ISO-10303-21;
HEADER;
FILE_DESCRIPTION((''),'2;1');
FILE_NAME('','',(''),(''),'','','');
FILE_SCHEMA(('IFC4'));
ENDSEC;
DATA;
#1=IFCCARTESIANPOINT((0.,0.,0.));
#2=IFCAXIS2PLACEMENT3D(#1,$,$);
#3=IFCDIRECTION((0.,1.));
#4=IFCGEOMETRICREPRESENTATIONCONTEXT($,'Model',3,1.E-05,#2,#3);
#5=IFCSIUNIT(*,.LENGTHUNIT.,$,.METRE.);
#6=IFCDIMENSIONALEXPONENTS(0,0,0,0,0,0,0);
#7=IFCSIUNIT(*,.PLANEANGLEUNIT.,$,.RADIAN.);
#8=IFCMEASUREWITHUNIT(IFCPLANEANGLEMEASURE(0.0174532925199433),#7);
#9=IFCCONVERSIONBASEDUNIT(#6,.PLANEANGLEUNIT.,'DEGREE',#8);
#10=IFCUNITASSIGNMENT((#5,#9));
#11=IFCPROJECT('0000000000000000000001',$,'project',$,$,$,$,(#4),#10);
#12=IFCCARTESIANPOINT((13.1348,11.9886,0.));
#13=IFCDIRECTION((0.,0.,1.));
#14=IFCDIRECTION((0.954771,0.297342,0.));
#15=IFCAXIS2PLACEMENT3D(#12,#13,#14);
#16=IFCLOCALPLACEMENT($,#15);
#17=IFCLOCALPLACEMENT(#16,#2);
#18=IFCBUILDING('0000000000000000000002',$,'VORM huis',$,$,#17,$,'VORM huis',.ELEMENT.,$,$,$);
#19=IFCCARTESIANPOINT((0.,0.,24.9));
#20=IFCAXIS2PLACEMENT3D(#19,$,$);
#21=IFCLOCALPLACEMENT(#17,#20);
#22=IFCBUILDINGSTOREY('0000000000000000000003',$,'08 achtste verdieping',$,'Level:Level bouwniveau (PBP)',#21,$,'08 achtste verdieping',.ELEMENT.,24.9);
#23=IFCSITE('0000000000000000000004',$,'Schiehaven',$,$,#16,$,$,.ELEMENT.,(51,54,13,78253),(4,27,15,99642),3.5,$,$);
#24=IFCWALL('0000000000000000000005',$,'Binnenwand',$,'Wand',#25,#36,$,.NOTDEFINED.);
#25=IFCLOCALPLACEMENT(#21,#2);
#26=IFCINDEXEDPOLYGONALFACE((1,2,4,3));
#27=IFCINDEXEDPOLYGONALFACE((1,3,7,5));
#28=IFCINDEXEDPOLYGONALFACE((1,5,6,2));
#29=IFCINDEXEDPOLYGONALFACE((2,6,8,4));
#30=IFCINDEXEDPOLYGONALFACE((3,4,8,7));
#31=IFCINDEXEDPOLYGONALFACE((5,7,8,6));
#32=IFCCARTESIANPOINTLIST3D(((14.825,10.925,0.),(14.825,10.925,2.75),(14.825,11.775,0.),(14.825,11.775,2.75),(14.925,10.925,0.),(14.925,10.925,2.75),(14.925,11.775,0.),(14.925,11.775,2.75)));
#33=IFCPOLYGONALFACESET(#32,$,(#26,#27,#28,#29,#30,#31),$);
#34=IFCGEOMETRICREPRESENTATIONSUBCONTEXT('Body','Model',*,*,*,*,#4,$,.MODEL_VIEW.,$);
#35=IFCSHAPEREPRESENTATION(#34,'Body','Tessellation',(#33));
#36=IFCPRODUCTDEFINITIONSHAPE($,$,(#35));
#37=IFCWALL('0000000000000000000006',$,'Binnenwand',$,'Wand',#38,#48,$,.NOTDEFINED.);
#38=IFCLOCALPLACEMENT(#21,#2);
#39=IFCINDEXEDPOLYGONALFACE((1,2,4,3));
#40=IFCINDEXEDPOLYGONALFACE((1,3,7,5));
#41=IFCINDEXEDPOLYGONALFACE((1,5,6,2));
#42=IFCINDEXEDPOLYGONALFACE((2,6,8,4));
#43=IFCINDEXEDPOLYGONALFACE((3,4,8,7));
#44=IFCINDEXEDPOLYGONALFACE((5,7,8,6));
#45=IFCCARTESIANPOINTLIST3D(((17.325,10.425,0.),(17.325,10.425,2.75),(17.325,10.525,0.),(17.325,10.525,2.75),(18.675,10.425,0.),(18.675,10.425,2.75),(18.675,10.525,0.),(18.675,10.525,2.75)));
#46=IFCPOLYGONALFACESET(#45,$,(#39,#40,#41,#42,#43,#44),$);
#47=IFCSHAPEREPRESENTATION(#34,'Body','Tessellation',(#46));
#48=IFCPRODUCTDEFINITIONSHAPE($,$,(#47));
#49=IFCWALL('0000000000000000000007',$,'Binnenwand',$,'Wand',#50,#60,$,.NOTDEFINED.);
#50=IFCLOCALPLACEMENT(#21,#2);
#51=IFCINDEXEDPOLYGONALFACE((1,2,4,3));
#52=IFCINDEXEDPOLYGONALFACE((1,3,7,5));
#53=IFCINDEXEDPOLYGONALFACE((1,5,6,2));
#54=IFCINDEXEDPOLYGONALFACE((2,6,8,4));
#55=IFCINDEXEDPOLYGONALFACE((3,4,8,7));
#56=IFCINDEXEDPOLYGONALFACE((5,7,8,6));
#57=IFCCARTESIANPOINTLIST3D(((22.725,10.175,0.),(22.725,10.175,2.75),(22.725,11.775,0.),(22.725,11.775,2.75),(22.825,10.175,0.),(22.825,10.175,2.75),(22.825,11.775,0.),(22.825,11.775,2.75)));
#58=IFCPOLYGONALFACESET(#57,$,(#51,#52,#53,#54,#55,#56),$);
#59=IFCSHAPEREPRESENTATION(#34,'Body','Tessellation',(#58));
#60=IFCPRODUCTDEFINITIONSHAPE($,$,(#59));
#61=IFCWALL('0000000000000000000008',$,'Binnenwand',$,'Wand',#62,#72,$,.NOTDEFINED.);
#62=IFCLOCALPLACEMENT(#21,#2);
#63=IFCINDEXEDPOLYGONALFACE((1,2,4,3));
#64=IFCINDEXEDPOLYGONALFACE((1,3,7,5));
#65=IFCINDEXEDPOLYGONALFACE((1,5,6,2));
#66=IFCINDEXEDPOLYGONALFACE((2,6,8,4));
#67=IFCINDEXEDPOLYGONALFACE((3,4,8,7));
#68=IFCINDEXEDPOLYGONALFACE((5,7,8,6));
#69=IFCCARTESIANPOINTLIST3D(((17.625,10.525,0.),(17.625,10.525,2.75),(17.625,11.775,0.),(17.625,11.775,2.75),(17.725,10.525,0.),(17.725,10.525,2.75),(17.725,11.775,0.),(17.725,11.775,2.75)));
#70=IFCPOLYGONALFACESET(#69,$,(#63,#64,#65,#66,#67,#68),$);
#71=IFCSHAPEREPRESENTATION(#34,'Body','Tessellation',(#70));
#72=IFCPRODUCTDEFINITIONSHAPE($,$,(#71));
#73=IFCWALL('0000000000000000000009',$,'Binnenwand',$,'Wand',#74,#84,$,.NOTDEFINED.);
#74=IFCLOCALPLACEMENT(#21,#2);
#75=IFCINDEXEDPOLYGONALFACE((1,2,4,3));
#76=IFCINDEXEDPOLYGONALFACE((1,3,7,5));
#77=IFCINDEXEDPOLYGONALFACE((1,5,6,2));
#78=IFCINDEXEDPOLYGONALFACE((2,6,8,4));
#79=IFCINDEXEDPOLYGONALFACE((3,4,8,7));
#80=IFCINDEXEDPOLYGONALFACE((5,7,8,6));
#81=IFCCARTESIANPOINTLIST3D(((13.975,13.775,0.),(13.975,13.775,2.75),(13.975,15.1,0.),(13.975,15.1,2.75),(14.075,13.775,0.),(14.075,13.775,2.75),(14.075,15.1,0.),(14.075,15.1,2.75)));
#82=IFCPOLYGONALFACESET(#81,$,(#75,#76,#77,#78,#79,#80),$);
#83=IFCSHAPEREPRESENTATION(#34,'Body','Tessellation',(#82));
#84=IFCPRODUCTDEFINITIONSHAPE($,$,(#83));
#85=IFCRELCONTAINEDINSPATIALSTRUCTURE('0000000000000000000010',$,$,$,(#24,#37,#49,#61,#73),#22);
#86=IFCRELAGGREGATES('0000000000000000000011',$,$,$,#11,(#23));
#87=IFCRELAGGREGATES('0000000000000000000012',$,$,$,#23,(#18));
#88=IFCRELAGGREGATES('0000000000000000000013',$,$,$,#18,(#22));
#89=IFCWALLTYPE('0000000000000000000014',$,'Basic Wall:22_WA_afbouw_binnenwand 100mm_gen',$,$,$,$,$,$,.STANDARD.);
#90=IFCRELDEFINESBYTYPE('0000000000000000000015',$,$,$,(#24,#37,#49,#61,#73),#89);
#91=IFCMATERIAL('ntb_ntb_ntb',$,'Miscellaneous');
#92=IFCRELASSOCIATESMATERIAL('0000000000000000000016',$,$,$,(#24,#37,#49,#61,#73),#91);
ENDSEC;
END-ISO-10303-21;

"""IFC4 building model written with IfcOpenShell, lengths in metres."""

from ifc_helpers import new_model, entity, si_unit, converted_unit, direction, frame, origin, place, context, subcontext, project, spatial, indexed_curve, outline, extrude, material, type_object, element, save


model = new_model("IFC4")

# Units and contexts
model_context = context("Model", 3, precision=1e-05, world=origin(), true_north=direction((0.0, 1.0)))
body_context = subcontext(model_context, "Body", "Model", "MODEL_VIEW")
ifc_project = project(units=[si_unit("LENGTHUNIT", "METRE"), converted_unit("PLANEANGLEUNIT", "DEGREE", entity("IfcPlaneAngleMeasure", 0.0174532925199433), si_unit("PLANEANGLEUNIT", "RADIAN"), dimensions=[0, 0, 0, 0, 0, 0, 0])], contexts=[model_context])

# Site, building, storey
site_placement = place(None, frame((13.1348, 11.9886, 0.0), z_axis=(0.0, 0.0, 1.0), x_axis=(0.954771, 0.297342, 0.0)))
site = spatial("IfcSite", under=ifc_project, at=site_placement, Name="Schiehaven", CompositionType="ELEMENT", RefLatitude=(51, 54, 13, 78253), RefLongitude=(4, 27, 15, 99642), RefElevation=3.5)
building_placement = place(site_placement, origin())
building = spatial("IfcBuilding", under=site, at=building_placement, Name="VORM huis", LongName="VORM huis", CompositionType="ELEMENT")
storey_placement = place(building_placement, frame((0.0, 0.0, 24.9)))
storey = spatial("IfcBuildingStorey", under=building, at=storey_placement, Name="08 achtste verdieping", ObjectType="Level:Level bouwniveau (PBP)", LongName="08 achtste verdieping", CompositionType="ELEMENT", Elevation=24.9)

# Walls
ifc_material_1 = material(Name="ntb_ntb_ntb", Category="Miscellaneous")
wall_type_1 = type_object("IfcWallType", Name="Basic Wall:22_WA_afbouw_binnenwand 100mm_gen", PredefinedType="STANDARD")
wall_1_placement = place(storey_placement, frame((14.875, 11.775, 0.0), z_axis=(0.0, 0.0, 1.0), x_axis=(0.0, -1.0, 0.0)))
element("IfcWall", 1, at=wall_1_placement, inside=storey, type_object=wall_type_1, material=ifc_material_1, Name="Binnenwand", ObjectType="Wand", PredefinedType="NOTDEFINED", context=body_context, shape_type="SweptSolid", body=[
    extrude(outline(indexed_curve([(0.85, 0.05), (0.0, 0.05), (0.0, -0.05), (0.85, -0.05), (0.85, 0.05)], self_intersect=False)), origin(), (0.0, 0.0, 1.0), 2.75),
])
wall_2_placement = place(storey_placement, frame((17.325, 10.475, 0.0)))
element("IfcWall", 2, at=wall_2_placement, inside=storey, type_object=wall_type_1, material=ifc_material_1, Name="Binnenwand", ObjectType="Wand", PredefinedType="NOTDEFINED", context=body_context, shape_type="SweptSolid", body=[
    extrude(outline(indexed_curve([(1.35, 0.05), (0.0, 0.05), (0.0, -0.05), (1.35, -0.05), (1.35, 0.05)], self_intersect=False)), origin(), (0.0, 0.0, 1.0), 2.75),
])
wall_3_placement = place(storey_placement, frame((22.775, 10.175, 0.0), z_axis=(0.0, 0.0, 1.0), x_axis=(0.0, 1.0, 0.0)))
element("IfcWall", 3, at=wall_3_placement, inside=storey, type_object=wall_type_1, material=ifc_material_1, Name="Binnenwand", ObjectType="Wand", PredefinedType="NOTDEFINED", context=body_context, shape_type="SweptSolid", body=[
    extrude(outline(indexed_curve([(1.6, 0.05), (0.0, 0.05), (0.0, -0.05), (1.6, -0.05), (1.6, 0.05)], self_intersect=False)), origin(), (0.0, 0.0, 1.0), 2.75),
])
wall_4_placement = place(storey_placement, frame((17.675, 11.775, 0.0), z_axis=(0.0, 0.0, 1.0), x_axis=(0.0, -1.0, 0.0)))
element("IfcWall", 4, at=wall_4_placement, inside=storey, type_object=wall_type_1, material=ifc_material_1, Name="Binnenwand", ObjectType="Wand", PredefinedType="NOTDEFINED", context=body_context, shape_type="SweptSolid", body=[
    extrude(outline(indexed_curve([(1.25, 0.05), (0.0, 0.05), (0.0, -0.05), (1.25, -0.05), (1.25, 0.05)], self_intersect=False)), origin(), (0.0, 0.0, 1.0), 2.75),
])
wall_5_placement = place(storey_placement, frame((14.025, 13.775, 0.0), z_axis=(0.0, 0.0, 1.0), x_axis=(0.0, 1.0, 0.0)))
element("IfcWall", 5, at=wall_5_placement, inside=storey, type_object=wall_type_1, material=ifc_material_1, Name="Binnenwand", ObjectType="Wand", PredefinedType="NOTDEFINED", context=body_context, shape_type="SweptSolid", body=[
    extrude(outline(indexed_curve([(1.325, 0.05), (0.0, 0.05), (0.0, -0.05), (1.325, -0.05), (1.325, 0.05)], self_intersect=False)), origin(), (0.0, 0.0, 1.0), 2.75),
])

save(model, "model.ifc")
